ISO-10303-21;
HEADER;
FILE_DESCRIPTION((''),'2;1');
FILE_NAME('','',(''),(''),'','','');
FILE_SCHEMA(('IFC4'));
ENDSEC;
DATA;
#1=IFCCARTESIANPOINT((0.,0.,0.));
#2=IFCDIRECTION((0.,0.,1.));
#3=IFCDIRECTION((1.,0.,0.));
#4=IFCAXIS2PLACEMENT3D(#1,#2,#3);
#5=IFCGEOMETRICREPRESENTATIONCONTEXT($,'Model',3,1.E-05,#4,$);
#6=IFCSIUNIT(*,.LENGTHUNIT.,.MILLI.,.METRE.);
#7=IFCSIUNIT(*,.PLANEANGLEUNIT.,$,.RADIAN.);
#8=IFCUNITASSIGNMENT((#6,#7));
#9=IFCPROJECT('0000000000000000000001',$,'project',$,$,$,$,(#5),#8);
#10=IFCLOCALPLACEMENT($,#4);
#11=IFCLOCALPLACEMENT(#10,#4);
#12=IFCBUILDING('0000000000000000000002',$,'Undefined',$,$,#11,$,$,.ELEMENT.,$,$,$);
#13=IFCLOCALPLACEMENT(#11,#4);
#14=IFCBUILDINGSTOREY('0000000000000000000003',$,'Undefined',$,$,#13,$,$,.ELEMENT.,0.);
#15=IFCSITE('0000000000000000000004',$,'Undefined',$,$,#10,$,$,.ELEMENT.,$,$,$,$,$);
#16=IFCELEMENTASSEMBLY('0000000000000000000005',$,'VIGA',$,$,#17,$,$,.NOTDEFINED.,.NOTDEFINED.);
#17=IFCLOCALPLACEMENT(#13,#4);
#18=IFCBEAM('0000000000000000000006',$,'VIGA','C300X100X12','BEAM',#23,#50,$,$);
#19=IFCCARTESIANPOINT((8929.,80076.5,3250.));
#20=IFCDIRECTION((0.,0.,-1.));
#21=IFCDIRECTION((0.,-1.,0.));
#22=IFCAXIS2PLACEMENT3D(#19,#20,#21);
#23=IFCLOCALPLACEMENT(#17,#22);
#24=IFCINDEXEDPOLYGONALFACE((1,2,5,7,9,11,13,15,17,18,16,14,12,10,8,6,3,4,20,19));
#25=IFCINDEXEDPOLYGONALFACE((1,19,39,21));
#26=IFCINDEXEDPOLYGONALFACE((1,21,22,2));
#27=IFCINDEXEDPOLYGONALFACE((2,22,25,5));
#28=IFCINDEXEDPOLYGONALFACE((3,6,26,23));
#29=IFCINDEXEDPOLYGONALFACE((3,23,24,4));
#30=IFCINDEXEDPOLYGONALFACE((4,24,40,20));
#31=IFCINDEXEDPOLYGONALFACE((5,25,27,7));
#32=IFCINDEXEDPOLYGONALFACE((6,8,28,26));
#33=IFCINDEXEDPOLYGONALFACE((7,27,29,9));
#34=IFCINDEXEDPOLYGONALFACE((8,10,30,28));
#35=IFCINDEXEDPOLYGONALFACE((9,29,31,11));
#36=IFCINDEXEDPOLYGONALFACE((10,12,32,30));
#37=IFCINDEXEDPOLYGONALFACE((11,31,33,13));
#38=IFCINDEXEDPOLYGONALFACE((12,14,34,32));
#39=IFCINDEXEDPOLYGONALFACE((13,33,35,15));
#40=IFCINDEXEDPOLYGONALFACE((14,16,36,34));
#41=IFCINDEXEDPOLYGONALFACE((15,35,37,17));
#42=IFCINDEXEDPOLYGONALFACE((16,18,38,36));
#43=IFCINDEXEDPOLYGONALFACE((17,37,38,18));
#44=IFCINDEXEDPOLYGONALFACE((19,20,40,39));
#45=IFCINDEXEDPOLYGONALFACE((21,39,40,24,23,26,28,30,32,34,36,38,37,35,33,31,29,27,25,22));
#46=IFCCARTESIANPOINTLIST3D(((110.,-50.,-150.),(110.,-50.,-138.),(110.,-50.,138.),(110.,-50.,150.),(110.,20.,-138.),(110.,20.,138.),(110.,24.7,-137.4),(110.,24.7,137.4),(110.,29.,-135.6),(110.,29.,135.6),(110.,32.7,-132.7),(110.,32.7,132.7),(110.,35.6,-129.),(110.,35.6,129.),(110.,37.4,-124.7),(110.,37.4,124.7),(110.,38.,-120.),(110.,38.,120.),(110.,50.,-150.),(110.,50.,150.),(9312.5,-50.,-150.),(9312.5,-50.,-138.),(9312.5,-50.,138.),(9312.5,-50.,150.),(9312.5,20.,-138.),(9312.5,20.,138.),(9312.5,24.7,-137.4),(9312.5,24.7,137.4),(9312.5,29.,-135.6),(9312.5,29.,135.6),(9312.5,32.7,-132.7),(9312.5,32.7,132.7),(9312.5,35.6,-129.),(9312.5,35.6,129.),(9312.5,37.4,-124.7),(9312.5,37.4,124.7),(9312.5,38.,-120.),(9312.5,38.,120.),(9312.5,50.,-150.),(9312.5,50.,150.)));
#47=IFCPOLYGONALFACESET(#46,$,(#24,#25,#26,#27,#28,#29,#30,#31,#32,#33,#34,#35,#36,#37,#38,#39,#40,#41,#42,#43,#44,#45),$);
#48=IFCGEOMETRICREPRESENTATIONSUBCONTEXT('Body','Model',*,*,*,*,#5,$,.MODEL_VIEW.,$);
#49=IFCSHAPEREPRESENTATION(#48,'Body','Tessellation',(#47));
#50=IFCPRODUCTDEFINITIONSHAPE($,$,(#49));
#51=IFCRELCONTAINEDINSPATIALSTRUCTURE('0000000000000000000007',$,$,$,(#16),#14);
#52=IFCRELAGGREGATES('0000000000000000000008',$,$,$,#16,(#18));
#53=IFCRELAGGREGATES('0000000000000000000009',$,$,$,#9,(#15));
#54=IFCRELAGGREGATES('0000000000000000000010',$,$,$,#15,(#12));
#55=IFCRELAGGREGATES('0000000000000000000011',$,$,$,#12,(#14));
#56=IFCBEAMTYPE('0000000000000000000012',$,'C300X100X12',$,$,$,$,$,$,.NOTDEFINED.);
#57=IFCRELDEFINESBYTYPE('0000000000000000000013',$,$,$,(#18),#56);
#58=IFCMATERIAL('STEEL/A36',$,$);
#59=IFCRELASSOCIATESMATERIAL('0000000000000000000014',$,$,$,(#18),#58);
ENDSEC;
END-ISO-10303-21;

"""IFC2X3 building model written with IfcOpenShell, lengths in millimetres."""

from ifc_helpers import new_model, si_unit, frame, origin_with_axes, origin_2d_with_axis, place, context, subcontext, project, spatial, u_section, extrude, clip, halfspace, material, type_object, element, aggregate, save


model = new_model("IFC2X3")

# Units and contexts
model_context = context("Model", 3, precision=1e-05, world=origin_with_axes())
body_context = subcontext(model_context, "Body", "Model", "MODEL_VIEW")
ifc_project = project(units=[si_unit("LENGTHUNIT", "METRE", prefix="MILLI"), si_unit("PLANEANGLEUNIT", "RADIAN")], contexts=[model_context])

# Site, building, storey
site_placement = place(None, origin_with_axes())
site = spatial("IfcSite", under=ifc_project, at=site_placement, Name="Undefined", CompositionType="ELEMENT")
building_placement = place(site_placement, origin_with_axes())
building = spatial("IfcBuilding", under=site, at=building_placement, Name="Undefined", CompositionType="ELEMENT")
storey_placement = place(building_placement, origin_with_axes())
storey = spatial("IfcBuildingStorey", under=building, at=storey_placement, Name="Undefined", CompositionType="ELEMENT", Elevation=0.0)

# Shared definitions
ifc_material_1 = material(Name="STEEL/A36")

# Element assembly, beam
assembly_1_placement = place(storey_placement, origin_with_axes())
assembly_1 = element("IfcElementAssembly", 1, at=assembly_1_placement, inside=storey, Name="VIGA", AssemblyPlace="NOTDEFINED", PredefinedType="NOTDEFINED")
beam_type_1 = type_object("IfcBeamType", Name="C300X100X12", PredefinedType="NOTDEFINED")
beam_1_placement = place(assembly_1_placement, frame((8929.0, 80076.5, 3250.0), z_axis=(0.0, 0.0, -1.0), x_axis=(0.0, -1.0, 0.0)))
beam_1 = element("IfcBeam", 2, at=beam_1_placement, type_object=beam_type_1, material=ifc_material_1, Name="VIGA", Description="C300X100X12", ObjectType="BEAM", context=body_context, shape_type="Clipping", body=[
    clip(extrude(u_section(Depth=300.0, FlangeWidth=100.0, WebThickness=12.0, FlangeThickness=12.0, FilletRadius=18.0, at=origin_2d_with_axis()), frame((9312.5, 0.0, 0.0), z_axis=(-1.0, 0.0, 0.0), x_axis=(0.0, -1.0, 0.0)), (0.0, 0.0, 1.0), 9312.5), halfspace(frame((110.0, 0.0, -250.0), z_axis=(-1.0, 0.0, 0.0), x_axis=(0.0, 1.0, 0.0)), False)),
])

aggregate(assembly_1, [beam_1])

save(model, "model.ifc")
